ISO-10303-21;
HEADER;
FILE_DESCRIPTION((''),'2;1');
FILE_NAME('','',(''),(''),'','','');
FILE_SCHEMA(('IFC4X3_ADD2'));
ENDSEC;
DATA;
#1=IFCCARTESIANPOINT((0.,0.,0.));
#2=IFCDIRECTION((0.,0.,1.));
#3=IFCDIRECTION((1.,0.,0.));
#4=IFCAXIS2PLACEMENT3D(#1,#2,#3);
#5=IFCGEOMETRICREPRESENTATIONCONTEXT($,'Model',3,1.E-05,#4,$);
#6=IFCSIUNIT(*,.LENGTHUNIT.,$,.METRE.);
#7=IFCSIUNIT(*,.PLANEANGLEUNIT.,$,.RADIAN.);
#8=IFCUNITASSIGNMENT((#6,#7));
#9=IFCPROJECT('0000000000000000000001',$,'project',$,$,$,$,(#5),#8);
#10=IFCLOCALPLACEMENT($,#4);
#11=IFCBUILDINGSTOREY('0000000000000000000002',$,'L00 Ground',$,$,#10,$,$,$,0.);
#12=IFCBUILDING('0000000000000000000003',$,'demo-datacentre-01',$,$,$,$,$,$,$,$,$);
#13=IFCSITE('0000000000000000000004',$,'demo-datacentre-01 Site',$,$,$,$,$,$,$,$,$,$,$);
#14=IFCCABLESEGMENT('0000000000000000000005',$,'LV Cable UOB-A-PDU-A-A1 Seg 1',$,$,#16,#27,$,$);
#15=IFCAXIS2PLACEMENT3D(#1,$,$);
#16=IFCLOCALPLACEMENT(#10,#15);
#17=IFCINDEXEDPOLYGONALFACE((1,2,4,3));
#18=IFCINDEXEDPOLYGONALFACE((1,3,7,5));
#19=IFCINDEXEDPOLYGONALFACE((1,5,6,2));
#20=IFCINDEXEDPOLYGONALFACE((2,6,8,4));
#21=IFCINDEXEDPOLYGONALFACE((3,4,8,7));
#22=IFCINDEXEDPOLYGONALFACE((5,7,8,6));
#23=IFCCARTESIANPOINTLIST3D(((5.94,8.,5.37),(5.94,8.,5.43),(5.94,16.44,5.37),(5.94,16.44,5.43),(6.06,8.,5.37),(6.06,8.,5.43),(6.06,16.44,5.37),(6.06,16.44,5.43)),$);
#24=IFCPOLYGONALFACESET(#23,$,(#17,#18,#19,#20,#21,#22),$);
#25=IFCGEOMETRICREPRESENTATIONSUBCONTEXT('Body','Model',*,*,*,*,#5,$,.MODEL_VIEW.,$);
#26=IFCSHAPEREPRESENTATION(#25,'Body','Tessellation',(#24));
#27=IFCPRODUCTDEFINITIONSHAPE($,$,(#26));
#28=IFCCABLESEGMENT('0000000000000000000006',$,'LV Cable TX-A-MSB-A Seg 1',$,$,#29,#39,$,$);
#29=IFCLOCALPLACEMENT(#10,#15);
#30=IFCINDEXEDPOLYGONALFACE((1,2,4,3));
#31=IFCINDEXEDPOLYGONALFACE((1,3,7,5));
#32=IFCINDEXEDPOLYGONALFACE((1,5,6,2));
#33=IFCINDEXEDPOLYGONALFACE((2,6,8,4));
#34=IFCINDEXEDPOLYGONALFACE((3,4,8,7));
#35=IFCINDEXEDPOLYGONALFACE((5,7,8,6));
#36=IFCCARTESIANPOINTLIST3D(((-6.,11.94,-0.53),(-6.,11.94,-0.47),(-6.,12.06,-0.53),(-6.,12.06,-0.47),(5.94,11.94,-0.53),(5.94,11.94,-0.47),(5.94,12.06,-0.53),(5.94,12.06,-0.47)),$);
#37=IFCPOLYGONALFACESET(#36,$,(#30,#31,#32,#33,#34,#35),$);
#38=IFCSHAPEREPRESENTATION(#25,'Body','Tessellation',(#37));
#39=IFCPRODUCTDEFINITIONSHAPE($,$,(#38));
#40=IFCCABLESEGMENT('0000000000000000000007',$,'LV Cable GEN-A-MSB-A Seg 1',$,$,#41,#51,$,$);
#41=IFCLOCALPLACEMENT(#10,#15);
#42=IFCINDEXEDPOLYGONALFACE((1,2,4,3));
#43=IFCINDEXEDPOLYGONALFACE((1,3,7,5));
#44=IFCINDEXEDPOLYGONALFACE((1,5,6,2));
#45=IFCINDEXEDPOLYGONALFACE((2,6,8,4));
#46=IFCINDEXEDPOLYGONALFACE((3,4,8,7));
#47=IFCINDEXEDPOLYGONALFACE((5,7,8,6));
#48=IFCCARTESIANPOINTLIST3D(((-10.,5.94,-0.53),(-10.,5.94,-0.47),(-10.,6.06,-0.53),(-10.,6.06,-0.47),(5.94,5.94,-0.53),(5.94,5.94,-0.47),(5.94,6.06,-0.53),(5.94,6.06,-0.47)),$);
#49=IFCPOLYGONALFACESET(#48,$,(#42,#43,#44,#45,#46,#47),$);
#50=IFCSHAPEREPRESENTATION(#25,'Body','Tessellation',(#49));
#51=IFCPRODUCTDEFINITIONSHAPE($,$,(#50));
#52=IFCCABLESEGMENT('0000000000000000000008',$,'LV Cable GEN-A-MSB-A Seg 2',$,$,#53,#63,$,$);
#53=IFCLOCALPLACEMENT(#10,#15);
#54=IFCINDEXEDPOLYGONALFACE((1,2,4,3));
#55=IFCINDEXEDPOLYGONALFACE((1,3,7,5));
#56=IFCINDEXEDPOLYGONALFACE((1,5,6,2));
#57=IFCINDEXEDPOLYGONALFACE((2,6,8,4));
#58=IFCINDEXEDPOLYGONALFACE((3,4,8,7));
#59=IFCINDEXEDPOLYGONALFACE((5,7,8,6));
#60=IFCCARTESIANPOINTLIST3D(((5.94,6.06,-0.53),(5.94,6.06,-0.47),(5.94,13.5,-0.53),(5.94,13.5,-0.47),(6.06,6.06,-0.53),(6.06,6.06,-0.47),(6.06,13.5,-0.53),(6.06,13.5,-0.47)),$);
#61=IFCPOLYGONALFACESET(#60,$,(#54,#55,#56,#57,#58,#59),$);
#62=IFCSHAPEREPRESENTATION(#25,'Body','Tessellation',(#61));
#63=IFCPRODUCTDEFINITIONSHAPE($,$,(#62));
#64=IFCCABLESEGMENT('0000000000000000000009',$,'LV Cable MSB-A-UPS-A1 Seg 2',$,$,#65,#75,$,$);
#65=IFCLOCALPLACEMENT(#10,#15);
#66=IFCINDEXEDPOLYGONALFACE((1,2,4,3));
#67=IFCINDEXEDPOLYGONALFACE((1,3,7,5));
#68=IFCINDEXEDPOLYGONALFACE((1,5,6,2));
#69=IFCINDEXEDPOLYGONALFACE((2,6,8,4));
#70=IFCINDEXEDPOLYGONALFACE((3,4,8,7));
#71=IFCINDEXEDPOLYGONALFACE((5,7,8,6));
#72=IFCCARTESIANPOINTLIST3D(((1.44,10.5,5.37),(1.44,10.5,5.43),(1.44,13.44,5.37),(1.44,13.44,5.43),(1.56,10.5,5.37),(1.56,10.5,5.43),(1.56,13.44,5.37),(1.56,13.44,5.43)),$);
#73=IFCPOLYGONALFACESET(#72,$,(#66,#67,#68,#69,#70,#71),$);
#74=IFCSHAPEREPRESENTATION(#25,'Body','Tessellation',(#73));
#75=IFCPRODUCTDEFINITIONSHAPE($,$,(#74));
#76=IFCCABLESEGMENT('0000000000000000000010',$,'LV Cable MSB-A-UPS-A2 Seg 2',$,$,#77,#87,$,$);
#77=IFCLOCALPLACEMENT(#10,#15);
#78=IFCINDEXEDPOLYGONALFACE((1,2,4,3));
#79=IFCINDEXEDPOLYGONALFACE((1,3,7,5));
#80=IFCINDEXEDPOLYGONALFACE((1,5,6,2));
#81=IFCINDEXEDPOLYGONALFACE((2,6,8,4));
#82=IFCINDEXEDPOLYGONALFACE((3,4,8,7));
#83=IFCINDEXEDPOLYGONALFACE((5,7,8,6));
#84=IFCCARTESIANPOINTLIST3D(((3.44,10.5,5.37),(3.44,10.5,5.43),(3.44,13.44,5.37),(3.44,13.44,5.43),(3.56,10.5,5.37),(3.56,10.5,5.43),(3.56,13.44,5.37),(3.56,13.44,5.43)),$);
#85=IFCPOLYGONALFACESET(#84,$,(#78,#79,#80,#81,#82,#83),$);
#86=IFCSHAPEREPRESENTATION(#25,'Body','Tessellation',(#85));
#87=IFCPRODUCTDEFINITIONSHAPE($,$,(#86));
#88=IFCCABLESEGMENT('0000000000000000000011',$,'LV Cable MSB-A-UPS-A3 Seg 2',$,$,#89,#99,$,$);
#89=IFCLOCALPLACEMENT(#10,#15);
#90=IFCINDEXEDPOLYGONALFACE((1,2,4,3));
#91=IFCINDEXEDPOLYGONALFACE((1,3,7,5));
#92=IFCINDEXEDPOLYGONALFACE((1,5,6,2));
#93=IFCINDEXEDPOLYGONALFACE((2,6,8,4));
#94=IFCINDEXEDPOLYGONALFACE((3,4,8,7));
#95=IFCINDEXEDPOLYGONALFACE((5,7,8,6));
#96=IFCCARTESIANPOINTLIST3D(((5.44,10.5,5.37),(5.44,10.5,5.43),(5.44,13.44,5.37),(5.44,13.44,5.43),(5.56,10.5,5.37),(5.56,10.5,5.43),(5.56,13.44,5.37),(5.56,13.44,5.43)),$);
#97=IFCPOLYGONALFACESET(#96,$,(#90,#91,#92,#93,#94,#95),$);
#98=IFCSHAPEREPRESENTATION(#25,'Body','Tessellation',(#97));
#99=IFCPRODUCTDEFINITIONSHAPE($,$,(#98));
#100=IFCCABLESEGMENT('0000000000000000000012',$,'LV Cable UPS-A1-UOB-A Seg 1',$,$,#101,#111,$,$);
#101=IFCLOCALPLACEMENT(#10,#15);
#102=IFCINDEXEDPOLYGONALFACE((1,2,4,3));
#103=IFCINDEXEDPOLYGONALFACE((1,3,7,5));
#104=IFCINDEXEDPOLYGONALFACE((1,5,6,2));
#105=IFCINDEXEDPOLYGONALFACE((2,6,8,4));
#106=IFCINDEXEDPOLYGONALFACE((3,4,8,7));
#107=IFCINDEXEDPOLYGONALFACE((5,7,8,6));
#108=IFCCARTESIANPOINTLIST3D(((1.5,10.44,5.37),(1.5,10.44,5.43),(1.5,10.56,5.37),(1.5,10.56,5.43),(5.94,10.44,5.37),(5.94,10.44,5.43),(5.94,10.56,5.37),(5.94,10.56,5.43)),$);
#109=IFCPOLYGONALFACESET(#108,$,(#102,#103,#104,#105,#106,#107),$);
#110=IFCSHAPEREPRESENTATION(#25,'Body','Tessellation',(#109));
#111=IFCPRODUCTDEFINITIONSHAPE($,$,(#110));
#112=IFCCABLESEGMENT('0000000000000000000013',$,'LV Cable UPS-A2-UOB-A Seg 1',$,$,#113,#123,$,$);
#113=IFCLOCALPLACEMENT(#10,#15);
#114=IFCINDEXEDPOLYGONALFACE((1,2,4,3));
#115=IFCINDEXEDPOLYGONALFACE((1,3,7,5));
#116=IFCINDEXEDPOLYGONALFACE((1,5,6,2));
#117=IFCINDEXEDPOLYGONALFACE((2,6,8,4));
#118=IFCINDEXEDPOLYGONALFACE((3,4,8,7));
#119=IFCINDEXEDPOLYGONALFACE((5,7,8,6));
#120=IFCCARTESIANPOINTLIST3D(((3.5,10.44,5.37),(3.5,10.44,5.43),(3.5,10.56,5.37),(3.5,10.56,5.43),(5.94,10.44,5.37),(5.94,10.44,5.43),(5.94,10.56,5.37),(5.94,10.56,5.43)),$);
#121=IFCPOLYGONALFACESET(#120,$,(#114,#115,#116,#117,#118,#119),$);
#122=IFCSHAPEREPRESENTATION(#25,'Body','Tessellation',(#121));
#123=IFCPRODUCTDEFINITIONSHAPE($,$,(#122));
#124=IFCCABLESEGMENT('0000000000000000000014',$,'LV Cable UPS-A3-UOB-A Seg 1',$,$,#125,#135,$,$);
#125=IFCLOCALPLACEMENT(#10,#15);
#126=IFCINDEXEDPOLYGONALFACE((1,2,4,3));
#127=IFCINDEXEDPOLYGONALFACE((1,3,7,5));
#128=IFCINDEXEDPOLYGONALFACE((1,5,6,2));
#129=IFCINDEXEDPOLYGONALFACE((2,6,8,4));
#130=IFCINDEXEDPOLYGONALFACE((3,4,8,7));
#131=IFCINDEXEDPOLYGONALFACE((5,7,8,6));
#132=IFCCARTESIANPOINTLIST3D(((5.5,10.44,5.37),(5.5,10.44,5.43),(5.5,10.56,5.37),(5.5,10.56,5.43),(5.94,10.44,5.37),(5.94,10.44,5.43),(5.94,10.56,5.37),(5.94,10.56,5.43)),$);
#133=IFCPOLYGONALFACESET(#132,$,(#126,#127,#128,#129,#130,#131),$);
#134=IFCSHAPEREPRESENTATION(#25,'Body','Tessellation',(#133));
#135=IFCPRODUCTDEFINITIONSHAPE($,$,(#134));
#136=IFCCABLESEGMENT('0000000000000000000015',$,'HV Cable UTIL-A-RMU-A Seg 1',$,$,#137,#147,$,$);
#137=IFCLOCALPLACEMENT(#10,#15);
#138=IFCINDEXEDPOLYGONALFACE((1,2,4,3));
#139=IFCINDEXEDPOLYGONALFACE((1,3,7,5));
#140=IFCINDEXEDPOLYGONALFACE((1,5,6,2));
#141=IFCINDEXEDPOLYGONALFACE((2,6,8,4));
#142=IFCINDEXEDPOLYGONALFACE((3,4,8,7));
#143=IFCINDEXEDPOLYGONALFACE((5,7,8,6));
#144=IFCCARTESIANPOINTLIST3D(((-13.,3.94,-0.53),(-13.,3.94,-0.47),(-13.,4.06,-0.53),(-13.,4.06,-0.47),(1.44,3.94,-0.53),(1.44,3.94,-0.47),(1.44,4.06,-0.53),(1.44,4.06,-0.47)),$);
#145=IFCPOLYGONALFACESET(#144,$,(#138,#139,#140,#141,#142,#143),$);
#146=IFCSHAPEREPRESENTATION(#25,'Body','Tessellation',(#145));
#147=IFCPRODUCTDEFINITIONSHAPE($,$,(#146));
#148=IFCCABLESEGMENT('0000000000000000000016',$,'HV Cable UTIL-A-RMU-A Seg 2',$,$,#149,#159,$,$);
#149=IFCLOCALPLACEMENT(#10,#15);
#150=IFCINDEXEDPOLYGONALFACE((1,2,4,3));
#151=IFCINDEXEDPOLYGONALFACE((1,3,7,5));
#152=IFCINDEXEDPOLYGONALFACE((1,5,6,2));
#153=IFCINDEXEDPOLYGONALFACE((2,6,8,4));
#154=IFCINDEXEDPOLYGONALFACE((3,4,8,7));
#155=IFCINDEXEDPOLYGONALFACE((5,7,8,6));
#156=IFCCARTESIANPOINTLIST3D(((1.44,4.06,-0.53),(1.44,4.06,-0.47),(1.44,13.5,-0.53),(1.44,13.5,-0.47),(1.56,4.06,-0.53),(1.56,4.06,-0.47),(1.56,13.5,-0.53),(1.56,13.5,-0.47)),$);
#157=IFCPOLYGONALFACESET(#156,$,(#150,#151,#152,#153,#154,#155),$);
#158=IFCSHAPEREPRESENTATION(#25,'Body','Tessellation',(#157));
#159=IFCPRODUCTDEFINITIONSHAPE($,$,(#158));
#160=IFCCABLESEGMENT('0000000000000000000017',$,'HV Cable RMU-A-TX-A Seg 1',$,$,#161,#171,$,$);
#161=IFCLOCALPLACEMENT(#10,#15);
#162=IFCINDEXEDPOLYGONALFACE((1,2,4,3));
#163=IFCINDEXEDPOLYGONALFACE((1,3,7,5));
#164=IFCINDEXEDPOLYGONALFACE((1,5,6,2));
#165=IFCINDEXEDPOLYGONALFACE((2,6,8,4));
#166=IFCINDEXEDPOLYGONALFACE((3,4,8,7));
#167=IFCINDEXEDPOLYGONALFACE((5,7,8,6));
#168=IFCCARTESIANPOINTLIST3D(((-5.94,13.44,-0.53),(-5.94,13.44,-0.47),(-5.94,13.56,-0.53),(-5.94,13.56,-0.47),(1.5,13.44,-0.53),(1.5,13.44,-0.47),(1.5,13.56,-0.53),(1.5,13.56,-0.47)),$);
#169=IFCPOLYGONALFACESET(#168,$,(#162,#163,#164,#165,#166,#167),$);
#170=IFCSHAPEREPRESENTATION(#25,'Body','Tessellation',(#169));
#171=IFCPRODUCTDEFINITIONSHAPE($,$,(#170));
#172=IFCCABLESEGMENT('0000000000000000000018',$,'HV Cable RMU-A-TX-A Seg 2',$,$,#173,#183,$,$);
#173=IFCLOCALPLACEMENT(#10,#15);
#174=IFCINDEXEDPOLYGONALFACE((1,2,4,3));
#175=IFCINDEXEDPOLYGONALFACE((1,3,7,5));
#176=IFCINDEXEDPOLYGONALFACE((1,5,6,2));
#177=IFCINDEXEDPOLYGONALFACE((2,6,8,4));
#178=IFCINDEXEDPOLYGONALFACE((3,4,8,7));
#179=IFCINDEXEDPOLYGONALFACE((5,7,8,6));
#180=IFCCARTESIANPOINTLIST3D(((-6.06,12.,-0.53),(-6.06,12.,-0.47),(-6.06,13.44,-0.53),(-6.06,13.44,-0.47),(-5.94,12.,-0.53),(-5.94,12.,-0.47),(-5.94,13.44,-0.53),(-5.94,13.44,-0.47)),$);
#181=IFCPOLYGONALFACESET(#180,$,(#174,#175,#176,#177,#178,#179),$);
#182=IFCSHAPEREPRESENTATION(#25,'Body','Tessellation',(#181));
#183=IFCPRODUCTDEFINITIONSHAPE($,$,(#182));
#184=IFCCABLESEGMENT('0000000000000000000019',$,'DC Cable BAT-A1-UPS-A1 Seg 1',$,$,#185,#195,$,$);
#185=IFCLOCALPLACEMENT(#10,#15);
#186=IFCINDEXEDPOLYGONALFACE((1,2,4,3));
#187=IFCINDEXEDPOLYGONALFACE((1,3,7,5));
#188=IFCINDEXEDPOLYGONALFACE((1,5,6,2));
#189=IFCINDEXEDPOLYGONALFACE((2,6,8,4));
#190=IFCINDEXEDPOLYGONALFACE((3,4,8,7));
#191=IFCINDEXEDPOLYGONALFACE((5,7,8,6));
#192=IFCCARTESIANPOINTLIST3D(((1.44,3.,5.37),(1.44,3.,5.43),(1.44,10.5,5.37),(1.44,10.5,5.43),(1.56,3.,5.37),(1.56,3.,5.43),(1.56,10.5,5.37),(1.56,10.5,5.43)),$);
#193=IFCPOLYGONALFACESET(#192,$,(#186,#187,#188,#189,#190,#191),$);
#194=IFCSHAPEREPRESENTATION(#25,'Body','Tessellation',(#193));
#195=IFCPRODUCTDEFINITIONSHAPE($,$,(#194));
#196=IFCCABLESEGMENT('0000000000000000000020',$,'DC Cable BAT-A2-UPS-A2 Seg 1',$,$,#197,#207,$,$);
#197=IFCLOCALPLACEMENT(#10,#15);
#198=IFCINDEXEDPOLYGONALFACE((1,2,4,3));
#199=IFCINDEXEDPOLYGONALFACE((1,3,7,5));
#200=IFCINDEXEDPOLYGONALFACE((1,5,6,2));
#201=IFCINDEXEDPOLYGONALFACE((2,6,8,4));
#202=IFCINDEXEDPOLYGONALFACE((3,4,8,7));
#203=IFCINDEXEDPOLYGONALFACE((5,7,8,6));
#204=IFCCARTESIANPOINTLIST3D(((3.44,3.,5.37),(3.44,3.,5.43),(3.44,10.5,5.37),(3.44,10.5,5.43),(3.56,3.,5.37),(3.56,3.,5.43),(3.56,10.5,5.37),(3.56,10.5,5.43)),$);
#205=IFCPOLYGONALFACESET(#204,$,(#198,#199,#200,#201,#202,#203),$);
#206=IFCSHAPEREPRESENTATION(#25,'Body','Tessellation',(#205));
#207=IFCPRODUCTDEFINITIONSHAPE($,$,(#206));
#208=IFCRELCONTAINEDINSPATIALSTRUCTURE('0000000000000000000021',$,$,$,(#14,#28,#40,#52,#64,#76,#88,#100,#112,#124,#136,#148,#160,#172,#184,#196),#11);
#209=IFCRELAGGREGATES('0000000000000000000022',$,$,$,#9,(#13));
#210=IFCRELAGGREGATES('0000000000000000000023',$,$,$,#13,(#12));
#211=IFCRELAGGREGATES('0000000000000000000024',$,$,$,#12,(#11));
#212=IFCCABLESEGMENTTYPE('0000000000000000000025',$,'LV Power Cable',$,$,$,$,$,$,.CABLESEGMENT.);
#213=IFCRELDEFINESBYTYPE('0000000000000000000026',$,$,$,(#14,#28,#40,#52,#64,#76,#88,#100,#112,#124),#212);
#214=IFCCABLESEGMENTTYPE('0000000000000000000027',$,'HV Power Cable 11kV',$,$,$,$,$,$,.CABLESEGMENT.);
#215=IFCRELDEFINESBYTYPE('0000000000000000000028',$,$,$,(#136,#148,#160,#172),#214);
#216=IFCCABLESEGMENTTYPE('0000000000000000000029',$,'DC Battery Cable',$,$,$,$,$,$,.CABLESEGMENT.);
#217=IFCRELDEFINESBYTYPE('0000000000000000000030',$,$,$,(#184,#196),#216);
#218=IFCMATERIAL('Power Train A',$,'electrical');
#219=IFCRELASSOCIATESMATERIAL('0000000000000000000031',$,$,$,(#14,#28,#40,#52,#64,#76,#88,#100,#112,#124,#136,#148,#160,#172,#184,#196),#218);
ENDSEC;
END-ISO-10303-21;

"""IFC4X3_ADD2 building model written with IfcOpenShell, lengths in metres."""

from ifc_helpers import new_model, si_unit, frame, origin_with_axes, place, context, subcontext, project, spatial, rectangle, extrude, material, type_object, element, save


model = new_model("IFC4X3_ADD2")

# Units and contexts
model_context = context("Model", 3, precision=1e-05, world=origin_with_axes())
body_context = subcontext(model_context, "Body", "Model", "MODEL_VIEW")
ifc_project = project(units=[si_unit("LENGTHUNIT", "METRE"), si_unit("PLANEANGLEUNIT", "RADIAN")], contexts=[model_context])

# Site, building, storey
site = spatial("IfcSite", under=ifc_project, Name="demo-datacentre-01 Site")
building = spatial("IfcBuilding", under=site, Name="demo-datacentre-01")
storey_placement = place(None, origin_with_axes())
storey = spatial("IfcBuildingStorey", under=building, at=storey_placement, Name="L00 Ground", Elevation=0.0)

# Shared definitions
ifc_material = material(Name="Power Train A", Category="electrical")

# Cable segments
cable_segment_type_1 = type_object("IfcCableSegmentType", Name="LV Power Cable", PredefinedType="CABLESEGMENT")
for number, where, z_axis, x_axis, name in (
    (1, (6.0, 8.0, 5.4), (0.0, 1.0, 0.0), (-1.0, 0.0, 0.0), "LV Cable UOB-A-PDU-A-A1 Seg 1"),
):
    element("IfcCableSegment", number, at=place(storey_placement, frame(where, z_axis=z_axis, x_axis=x_axis)), inside=storey, type_object=cable_segment_type_1, material=ifc_material, Name=name, context=body_context, shape_type="SweptSolid", body=[
        extrude(rectangle(XDim=0.12, YDim=0.06), origin_with_axes(), (0.0, 0.0, 1.0), 8.44),
    ])
cable_segment_1_placement = place(storey_placement, frame((-6.0, 12.0, -0.5), z_axis=(1.0, 0.0, 0.0), x_axis=(0.0, 1.0, 0.0)))
element("IfcCableSegment", 2, at=cable_segment_1_placement, inside=storey, type_object=cable_segment_type_1, material=ifc_material, Name="LV Cable TX-A-MSB-A Seg 1", context=body_context, shape_type="SweptSolid", body=[
    extrude(rectangle(XDim=0.12, YDim=0.06), origin_with_axes(), (0.0, 0.0, 1.0), 11.94),
])
cable_segment_2_placement = place(storey_placement, frame((-10.0, 6.0, -0.5), z_axis=(1.0, 0.0, 0.0), x_axis=(0.0, 1.0, 0.0)))
element("IfcCableSegment", 3, at=cable_segment_2_placement, inside=storey, type_object=cable_segment_type_1, material=ifc_material, Name="LV Cable GEN-A-MSB-A Seg 1", context=body_context, shape_type="SweptSolid", body=[
    extrude(rectangle(XDim=0.12, YDim=0.06), origin_with_axes(), (0.0, 0.0, 1.0), 15.94),
])
cable_segment_3_placement = place(storey_placement, frame((6.0, 6.06, -0.5), z_axis=(0.0, 1.0, 0.0), x_axis=(-1.0, 0.0, 0.0)))
element("IfcCableSegment", 4, at=cable_segment_3_placement, inside=storey, type_object=cable_segment_type_1, material=ifc_material, Name="LV Cable GEN-A-MSB-A Seg 2", context=body_context, shape_type="SweptSolid", body=[
    extrude(rectangle(XDim=0.12, YDim=0.06), origin_with_axes(), (0.0, 0.0, 1.0), 7.44),
])
for number, where, z_axis, x_axis, name in (
    (5, (1.5, 13.44, 5.4), (0.0, -1.0, 0.0), (1.0, 0.0, 0.0), "LV Cable MSB-A-UPS-A1 Seg 2"),
    (6, (3.5, 13.44, 5.4), (0.0, -1.0, 0.0), (1.0, 0.0, 0.0), "LV Cable MSB-A-UPS-A2 Seg 2"),
    (7, (5.5, 13.44, 5.4), (0.0, -1.0, 0.0), (1.0, 0.0, 0.0), "LV Cable MSB-A-UPS-A3 Seg 2"),
):
    element("IfcCableSegment", number, at=place(storey_placement, frame(where, z_axis=z_axis, x_axis=x_axis)), inside=storey, type_object=cable_segment_type_1, material=ifc_material, Name=name, context=body_context, shape_type="SweptSolid", body=[
        extrude(rectangle(XDim=0.12, YDim=0.06), origin_with_axes(), (0.0, 0.0, 1.0), 2.94),
    ])
cable_segment_4_placement = place(storey_placement, frame((1.5, 10.5, 5.4), z_axis=(1.0, 0.0, 0.0), x_axis=(0.0, 1.0, 0.0)))
element("IfcCableSegment", 8, at=cable_segment_4_placement, inside=storey, type_object=cable_segment_type_1, material=ifc_material, Name="LV Cable UPS-A1-UOB-A Seg 1", context=body_context, shape_type="SweptSolid", body=[
    extrude(rectangle(XDim=0.12, YDim=0.06), origin_with_axes(), (0.0, 0.0, 1.0), 4.44),
])
cable_segment_5_placement = place(storey_placement, frame((3.5, 10.5, 5.4), z_axis=(1.0, 0.0, 0.0), x_axis=(0.0, 1.0, 0.0)))
element("IfcCableSegment", 9, at=cable_segment_5_placement, inside=storey, type_object=cable_segment_type_1, material=ifc_material, Name="LV Cable UPS-A2-UOB-A Seg 1", context=body_context, shape_type="SweptSolid", body=[
    extrude(rectangle(XDim=0.12, YDim=0.06), origin_with_axes(), (0.0, 0.0, 1.0), 2.44),
])
cable_segment_6_placement = place(storey_placement, frame((5.5, 10.5, 5.4), z_axis=(1.0, 0.0, 0.0), x_axis=(0.0, 1.0, 0.0)))
element("IfcCableSegment", 10, at=cable_segment_6_placement, inside=storey, type_object=cable_segment_type_1, material=ifc_material, Name="LV Cable UPS-A3-UOB-A Seg 1", context=body_context, shape_type="SweptSolid", body=[
    extrude(rectangle(XDim=0.12, YDim=0.06), origin_with_axes(), (0.0, 0.0, 1.0), 0.44),
])
cable_segment_type_2 = type_object("IfcCableSegmentType", Name="HV Power Cable 11kV", PredefinedType="CABLESEGMENT")
cable_segment_7_placement = place(storey_placement, frame((-13.0, 4.0, -0.5), z_axis=(1.0, 0.0, 0.0), x_axis=(0.0, 1.0, 0.0)))
element("IfcCableSegment", 11, at=cable_segment_7_placement, inside=storey, type_object=cable_segment_type_2, material=ifc_material, Name="HV Cable UTIL-A-RMU-A Seg 1", context=body_context, shape_type="SweptSolid", body=[
    extrude(rectangle(XDim=0.12, YDim=0.06), origin_with_axes(), (0.0, 0.0, 1.0), 14.44),
])
cable_segment_8_placement = place(storey_placement, frame((1.5, 4.06, -0.5), z_axis=(0.0, 1.0, 0.0), x_axis=(-1.0, 0.0, 0.0)))
element("IfcCableSegment", 12, at=cable_segment_8_placement, inside=storey, type_object=cable_segment_type_2, material=ifc_material, Name="HV Cable UTIL-A-RMU-A Seg 2", context=body_context, shape_type="SweptSolid", body=[
    extrude(rectangle(XDim=0.12, YDim=0.06), origin_with_axes(), (0.0, 0.0, 1.0), 9.44),
])
cable_segment_9_placement = place(storey_placement, frame((1.5, 13.5, -0.5), z_axis=(-1.0, 0.0, 0.0), x_axis=(0.0, -1.0, 0.0)))
element("IfcCableSegment", 13, at=cable_segment_9_placement, inside=storey, type_object=cable_segment_type_2, material=ifc_material, Name="HV Cable RMU-A-TX-A Seg 1", context=body_context, shape_type="SweptSolid", body=[
    extrude(rectangle(XDim=0.12, YDim=0.06), origin_with_axes(), (0.0, 0.0, 1.0), 7.44),
])
cable_segment_10_placement = place(storey_placement, frame((-6.0, 13.44, -0.5), z_axis=(0.0, -1.0, 0.0), x_axis=(1.0, 0.0, 0.0)))
element("IfcCableSegment", 14, at=cable_segment_10_placement, inside=storey, type_object=cable_segment_type_2, material=ifc_material, Name="HV Cable RMU-A-TX-A Seg 2", context=body_context, shape_type="SweptSolid", body=[
    extrude(rectangle(XDim=0.12, YDim=0.06), origin_with_axes(), (0.0, 0.0, 1.0), 1.44),
])
cable_segment_type_3 = type_object("IfcCableSegmentType", Name="DC Battery Cable", PredefinedType="CABLESEGMENT")
for number, where, z_axis, x_axis, name in (
    (15, (1.5, 3.0, 5.4), (0.0, 1.0, 0.0), (-1.0, 0.0, 0.0), "DC Cable BAT-A1-UPS-A1 Seg 1"),
    (16, (3.5, 3.0, 5.4), (0.0, 1.0, 0.0), (-1.0, 0.0, 0.0), "DC Cable BAT-A2-UPS-A2 Seg 1"),
):
    element("IfcCableSegment", number, at=place(storey_placement, frame(where, z_axis=z_axis, x_axis=x_axis)), inside=storey, type_object=cable_segment_type_3, material=ifc_material, Name=name, context=body_context, shape_type="SweptSolid", body=[
        extrude(rectangle(XDim=0.12, YDim=0.06), origin_with_axes(), (0.0, 0.0, 1.0), 7.5),
    ])

save(model, "model.ifc")
